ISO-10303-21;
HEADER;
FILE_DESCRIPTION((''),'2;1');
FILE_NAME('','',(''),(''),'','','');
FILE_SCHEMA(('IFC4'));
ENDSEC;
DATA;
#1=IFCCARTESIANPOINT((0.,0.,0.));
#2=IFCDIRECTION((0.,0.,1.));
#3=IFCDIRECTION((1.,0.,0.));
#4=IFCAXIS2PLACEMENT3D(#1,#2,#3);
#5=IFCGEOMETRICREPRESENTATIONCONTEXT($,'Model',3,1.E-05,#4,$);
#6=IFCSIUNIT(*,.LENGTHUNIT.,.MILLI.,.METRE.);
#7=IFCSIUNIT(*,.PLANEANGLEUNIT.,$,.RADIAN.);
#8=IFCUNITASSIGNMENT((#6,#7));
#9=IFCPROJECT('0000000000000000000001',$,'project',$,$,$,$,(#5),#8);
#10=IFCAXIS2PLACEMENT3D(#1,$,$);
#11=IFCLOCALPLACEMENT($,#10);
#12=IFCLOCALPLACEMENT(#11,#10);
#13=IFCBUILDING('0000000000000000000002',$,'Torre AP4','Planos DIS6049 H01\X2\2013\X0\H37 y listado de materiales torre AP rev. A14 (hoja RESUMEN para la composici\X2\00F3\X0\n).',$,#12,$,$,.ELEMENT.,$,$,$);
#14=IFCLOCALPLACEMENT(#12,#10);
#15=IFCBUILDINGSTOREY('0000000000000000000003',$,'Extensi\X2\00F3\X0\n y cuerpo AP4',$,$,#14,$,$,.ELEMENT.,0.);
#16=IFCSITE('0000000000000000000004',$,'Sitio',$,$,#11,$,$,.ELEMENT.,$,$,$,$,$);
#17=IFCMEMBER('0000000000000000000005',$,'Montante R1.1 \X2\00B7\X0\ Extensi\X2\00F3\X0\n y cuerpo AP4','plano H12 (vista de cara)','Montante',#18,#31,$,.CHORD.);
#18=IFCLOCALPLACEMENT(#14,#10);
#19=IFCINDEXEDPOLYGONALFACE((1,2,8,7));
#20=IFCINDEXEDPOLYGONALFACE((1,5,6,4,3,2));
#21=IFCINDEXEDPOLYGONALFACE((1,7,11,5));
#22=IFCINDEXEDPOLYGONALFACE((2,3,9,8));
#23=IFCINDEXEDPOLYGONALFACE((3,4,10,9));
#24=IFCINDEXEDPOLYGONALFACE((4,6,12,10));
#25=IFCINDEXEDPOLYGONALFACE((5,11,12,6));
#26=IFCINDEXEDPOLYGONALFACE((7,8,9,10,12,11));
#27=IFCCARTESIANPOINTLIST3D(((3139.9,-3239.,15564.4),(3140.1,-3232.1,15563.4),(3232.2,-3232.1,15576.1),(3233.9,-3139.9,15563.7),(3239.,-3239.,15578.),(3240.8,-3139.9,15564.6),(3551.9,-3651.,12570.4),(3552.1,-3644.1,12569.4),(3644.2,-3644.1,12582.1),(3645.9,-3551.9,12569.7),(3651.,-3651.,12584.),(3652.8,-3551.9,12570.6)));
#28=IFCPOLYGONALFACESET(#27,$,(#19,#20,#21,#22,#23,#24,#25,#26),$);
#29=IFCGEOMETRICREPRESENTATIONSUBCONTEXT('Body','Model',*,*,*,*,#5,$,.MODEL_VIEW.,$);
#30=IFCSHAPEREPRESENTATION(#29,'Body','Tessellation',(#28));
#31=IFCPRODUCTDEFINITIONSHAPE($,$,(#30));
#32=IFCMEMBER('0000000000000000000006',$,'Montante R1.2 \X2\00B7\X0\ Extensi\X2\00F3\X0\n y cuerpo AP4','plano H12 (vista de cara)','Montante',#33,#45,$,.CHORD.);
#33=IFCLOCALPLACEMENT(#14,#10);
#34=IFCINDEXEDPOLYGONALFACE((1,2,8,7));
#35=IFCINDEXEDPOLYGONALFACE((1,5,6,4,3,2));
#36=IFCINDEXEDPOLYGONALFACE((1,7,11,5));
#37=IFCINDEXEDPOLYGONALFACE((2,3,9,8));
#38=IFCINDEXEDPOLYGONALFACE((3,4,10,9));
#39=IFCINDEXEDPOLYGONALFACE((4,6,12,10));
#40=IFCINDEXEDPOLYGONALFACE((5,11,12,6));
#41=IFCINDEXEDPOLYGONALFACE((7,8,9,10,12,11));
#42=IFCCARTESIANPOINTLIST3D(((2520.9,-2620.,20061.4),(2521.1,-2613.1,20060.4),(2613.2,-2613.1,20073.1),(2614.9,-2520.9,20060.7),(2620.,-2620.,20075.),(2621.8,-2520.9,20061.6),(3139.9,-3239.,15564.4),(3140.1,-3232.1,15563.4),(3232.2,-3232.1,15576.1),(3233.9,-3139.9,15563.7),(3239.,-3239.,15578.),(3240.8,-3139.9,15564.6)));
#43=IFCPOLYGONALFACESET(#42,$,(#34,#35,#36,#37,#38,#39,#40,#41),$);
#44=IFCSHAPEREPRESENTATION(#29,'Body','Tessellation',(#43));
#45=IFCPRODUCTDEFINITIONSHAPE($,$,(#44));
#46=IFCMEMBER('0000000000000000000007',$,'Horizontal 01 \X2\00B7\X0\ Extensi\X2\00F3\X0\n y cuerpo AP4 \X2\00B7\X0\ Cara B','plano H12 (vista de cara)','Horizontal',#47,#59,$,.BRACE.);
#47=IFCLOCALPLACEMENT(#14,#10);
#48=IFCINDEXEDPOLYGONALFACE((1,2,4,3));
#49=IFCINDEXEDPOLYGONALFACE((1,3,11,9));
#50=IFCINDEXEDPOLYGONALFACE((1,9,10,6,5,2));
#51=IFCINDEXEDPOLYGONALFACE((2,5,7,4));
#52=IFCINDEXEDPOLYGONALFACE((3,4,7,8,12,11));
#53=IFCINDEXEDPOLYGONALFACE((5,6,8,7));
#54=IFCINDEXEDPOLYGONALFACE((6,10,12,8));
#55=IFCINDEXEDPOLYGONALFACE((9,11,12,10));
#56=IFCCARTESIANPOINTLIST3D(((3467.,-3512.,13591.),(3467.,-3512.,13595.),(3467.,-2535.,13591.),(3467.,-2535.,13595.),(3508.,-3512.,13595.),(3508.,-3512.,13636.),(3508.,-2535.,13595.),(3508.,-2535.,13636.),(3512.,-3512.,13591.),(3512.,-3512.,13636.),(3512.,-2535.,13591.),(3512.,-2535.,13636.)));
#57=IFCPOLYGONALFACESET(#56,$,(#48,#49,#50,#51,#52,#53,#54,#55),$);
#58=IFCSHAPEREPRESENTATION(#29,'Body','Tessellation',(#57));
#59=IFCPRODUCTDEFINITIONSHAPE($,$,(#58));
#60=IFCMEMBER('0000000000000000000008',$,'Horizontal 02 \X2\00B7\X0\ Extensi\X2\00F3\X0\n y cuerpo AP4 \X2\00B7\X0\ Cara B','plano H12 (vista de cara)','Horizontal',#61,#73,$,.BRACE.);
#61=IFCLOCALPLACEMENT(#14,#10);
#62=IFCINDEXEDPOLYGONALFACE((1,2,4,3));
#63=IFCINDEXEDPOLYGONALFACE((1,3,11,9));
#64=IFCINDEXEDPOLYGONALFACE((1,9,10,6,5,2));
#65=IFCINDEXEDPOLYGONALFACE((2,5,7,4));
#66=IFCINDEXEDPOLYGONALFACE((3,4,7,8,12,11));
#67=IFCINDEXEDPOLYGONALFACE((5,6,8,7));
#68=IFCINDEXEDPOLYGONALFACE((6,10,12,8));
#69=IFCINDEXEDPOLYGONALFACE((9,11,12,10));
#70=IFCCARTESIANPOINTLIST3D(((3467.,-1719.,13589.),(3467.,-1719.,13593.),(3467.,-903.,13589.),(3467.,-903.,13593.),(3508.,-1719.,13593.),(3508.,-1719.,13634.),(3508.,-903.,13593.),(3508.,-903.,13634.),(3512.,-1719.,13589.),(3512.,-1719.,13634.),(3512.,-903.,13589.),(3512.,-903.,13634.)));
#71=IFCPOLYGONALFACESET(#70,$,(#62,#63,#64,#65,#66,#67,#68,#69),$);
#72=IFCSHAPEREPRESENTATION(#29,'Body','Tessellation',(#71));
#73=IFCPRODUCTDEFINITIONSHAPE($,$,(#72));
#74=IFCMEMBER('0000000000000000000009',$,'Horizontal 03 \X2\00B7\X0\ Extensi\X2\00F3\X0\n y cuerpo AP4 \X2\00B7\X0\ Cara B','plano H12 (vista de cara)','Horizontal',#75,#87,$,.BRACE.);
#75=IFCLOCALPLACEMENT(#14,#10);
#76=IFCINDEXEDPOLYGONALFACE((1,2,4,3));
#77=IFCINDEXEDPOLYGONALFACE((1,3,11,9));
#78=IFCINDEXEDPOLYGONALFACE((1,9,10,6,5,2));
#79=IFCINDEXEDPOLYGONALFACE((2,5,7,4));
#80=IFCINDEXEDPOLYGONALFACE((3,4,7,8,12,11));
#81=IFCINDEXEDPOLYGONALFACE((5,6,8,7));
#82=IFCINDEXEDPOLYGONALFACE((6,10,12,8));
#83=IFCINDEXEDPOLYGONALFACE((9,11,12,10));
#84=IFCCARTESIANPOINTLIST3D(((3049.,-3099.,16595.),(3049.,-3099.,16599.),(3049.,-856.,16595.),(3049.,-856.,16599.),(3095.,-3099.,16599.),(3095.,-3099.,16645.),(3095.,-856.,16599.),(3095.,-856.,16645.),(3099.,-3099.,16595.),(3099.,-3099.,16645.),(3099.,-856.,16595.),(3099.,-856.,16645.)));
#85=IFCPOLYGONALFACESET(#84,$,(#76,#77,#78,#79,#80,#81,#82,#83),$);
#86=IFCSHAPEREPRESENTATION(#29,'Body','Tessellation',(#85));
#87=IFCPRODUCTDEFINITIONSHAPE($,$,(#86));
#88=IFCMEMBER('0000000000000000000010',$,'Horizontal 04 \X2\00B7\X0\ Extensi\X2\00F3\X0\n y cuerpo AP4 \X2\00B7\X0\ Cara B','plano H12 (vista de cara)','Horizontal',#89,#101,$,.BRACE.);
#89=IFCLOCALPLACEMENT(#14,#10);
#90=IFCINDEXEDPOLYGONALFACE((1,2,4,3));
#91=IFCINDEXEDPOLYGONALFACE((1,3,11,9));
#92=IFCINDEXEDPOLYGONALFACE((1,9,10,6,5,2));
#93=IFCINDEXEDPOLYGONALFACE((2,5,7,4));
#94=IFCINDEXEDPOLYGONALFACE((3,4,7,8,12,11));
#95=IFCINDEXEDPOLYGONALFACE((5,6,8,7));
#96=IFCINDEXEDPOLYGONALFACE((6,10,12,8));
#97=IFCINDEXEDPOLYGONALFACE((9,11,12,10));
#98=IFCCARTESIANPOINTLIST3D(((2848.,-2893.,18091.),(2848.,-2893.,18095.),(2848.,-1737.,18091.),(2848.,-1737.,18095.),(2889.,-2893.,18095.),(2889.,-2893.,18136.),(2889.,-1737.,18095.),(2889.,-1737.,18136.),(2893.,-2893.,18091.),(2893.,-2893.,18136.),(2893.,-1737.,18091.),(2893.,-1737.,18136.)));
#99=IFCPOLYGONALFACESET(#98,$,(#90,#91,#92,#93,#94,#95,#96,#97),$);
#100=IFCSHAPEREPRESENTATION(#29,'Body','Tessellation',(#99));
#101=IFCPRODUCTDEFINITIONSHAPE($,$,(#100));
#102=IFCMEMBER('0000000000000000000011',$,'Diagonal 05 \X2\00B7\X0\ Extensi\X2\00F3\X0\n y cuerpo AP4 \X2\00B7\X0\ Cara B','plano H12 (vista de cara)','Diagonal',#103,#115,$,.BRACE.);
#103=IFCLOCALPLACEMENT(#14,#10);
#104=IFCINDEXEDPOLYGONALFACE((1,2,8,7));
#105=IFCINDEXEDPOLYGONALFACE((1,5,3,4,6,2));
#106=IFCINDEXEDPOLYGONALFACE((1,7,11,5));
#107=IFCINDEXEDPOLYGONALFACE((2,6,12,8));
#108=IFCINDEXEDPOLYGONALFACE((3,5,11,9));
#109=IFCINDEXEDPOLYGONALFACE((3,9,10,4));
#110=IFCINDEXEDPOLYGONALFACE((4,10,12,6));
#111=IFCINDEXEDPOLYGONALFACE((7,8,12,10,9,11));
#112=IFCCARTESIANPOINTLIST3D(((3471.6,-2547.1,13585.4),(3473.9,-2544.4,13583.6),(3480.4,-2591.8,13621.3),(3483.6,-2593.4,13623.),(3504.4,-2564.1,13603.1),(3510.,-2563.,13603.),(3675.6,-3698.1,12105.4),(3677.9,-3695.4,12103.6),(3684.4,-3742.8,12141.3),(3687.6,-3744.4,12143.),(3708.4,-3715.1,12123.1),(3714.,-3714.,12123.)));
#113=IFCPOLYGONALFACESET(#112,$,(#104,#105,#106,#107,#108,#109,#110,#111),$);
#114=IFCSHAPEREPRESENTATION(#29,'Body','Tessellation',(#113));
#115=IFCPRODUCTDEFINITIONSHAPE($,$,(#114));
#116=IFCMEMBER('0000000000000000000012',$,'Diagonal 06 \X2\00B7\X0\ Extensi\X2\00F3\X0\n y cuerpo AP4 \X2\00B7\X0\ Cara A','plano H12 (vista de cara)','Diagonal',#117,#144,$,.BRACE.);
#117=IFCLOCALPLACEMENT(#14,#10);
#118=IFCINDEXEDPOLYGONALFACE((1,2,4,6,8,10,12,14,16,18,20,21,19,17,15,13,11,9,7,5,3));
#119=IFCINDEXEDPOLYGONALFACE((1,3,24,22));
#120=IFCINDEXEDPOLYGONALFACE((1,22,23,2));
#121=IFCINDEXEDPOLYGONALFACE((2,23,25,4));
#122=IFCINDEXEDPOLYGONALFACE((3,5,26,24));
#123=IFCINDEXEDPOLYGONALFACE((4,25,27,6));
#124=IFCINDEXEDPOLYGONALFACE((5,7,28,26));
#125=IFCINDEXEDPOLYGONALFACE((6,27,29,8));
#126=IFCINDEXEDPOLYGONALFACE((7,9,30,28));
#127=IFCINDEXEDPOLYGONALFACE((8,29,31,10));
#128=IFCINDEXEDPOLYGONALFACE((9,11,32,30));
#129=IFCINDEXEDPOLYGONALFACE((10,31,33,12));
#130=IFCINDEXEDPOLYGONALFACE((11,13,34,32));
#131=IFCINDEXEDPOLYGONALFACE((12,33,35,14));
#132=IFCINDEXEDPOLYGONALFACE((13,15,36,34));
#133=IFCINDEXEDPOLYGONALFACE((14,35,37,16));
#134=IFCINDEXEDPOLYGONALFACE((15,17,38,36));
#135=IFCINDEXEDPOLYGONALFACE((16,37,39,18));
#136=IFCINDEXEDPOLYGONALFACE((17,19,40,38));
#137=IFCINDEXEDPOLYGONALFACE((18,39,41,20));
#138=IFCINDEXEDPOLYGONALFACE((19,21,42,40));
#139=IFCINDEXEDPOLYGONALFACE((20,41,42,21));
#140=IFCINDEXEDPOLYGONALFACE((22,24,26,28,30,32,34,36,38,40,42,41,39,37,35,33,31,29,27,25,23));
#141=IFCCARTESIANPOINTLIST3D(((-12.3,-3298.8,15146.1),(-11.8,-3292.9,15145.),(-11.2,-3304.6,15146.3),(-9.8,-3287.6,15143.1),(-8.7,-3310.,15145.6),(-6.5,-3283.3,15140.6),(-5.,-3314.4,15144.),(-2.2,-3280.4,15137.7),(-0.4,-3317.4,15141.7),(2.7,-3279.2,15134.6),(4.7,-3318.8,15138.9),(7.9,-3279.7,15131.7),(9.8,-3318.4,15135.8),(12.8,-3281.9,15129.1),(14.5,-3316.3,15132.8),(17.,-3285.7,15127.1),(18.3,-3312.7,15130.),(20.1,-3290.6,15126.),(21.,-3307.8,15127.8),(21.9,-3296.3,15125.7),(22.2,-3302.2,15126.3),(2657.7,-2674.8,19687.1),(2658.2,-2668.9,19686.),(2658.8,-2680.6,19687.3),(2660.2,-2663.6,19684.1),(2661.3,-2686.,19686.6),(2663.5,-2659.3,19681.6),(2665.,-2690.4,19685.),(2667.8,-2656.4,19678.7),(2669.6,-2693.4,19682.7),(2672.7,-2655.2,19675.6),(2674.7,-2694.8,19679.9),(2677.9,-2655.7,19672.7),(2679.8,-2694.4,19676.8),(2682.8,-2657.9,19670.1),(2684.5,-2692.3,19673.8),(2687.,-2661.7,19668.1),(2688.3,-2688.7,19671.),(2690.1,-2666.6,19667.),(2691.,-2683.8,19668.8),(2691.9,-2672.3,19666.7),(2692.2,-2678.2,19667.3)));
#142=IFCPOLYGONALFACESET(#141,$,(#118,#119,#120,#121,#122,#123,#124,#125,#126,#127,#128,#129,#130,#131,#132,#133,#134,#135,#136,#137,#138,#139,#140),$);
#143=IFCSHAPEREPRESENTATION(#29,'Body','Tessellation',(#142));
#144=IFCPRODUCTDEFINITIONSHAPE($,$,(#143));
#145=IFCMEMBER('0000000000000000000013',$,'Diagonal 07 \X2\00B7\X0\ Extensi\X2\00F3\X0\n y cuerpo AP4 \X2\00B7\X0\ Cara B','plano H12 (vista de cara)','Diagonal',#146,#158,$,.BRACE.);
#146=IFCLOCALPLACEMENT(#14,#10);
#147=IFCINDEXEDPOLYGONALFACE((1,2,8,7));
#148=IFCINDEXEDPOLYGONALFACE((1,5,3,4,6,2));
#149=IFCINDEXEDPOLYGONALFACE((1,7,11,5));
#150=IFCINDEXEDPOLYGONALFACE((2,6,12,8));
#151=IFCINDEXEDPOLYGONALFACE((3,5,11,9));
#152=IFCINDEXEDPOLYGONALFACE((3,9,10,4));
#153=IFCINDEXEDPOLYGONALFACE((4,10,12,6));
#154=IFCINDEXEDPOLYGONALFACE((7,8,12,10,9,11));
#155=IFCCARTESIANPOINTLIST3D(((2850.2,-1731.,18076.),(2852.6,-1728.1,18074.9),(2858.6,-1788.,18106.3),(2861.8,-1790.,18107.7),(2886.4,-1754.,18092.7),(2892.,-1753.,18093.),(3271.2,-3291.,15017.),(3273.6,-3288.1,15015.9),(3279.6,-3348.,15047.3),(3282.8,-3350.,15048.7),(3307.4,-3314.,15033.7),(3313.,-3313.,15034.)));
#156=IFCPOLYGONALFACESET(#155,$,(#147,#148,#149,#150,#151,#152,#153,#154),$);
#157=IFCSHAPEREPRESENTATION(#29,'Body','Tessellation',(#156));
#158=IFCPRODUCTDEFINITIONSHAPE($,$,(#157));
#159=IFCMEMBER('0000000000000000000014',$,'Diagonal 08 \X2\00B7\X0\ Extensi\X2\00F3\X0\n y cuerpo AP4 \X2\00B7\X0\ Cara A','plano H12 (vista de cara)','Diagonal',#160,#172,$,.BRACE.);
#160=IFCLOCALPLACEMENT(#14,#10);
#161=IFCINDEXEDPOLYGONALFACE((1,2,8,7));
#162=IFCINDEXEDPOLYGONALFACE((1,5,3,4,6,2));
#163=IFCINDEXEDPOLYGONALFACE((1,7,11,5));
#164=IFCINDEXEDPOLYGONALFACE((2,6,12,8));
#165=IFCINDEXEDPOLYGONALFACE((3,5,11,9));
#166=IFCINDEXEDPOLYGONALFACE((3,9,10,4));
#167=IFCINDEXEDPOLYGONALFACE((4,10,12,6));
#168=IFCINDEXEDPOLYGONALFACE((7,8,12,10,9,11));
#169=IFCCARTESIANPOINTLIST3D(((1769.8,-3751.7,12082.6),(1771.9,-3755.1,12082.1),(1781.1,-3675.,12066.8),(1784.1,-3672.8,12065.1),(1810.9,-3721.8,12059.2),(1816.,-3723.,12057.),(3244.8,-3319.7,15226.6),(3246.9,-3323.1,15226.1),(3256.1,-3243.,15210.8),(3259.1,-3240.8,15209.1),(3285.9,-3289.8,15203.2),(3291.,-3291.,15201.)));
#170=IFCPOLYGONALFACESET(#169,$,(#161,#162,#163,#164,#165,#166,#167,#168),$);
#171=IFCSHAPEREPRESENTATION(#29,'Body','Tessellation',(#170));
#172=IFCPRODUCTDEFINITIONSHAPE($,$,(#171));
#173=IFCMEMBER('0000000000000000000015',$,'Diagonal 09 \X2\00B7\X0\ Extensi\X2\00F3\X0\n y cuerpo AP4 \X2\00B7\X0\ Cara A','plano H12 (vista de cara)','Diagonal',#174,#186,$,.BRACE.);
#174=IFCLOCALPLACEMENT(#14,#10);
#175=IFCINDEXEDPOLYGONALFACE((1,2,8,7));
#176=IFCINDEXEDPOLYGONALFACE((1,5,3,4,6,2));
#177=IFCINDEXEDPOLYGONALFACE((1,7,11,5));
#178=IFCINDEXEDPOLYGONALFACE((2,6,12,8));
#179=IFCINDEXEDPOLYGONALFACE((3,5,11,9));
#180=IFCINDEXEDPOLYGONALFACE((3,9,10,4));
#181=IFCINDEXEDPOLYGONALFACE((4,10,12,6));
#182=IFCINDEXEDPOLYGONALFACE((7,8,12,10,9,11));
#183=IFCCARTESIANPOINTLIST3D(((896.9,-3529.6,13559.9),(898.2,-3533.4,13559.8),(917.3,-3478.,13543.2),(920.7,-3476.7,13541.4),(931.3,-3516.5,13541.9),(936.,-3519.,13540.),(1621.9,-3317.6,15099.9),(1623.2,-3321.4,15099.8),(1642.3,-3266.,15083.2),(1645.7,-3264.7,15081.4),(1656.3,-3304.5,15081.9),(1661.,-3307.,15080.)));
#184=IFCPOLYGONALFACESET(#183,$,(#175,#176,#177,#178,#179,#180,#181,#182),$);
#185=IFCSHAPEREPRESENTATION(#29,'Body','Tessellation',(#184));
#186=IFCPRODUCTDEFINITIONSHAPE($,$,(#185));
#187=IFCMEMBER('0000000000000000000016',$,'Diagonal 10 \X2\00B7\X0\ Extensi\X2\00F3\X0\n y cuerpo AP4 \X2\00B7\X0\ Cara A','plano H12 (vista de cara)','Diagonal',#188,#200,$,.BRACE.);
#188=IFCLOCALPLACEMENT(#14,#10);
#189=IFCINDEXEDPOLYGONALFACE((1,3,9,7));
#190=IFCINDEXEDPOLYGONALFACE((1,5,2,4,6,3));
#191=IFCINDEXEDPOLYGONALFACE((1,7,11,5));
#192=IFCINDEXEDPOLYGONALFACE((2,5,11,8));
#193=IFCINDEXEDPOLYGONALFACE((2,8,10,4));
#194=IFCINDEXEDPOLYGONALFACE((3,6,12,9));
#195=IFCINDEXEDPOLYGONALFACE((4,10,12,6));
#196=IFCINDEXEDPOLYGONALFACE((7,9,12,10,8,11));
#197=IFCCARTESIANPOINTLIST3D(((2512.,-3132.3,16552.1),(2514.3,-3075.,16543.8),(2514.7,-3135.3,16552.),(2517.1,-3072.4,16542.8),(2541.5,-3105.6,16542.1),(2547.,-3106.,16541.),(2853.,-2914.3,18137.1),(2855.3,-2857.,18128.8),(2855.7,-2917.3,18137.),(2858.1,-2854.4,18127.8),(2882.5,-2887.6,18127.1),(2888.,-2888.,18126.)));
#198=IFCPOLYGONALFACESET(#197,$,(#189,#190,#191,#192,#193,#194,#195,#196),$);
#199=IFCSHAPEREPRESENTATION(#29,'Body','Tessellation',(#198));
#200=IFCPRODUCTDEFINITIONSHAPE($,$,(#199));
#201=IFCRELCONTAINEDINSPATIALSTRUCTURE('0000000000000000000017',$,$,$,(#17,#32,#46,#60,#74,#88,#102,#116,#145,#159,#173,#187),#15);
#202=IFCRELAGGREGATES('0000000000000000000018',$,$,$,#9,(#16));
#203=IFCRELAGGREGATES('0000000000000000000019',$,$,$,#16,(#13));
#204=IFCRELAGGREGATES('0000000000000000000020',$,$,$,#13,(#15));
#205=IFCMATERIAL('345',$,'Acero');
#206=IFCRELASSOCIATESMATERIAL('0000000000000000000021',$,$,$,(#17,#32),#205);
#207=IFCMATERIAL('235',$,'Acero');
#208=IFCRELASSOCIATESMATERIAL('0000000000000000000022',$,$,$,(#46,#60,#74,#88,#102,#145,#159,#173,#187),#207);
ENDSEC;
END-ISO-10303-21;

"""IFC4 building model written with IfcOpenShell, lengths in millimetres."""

from ifc_helpers import new_model, si_unit, frame, frame_2d, origin, origin_with_axes, place, context, subcontext, project, spatial, circle, l_section, extrude, material, element, save


model = new_model("IFC4")

# Units and contexts
model_context = context("Model", 3, precision=1e-05, world=origin_with_axes())
body_context = subcontext(model_context, "Body", "Model", "MODEL_VIEW")
ifc_project = project(units=[si_unit("LENGTHUNIT", "METRE", prefix="MILLI"), si_unit("PLANEANGLEUNIT", "RADIAN")], contexts=[model_context])

# Site, building, storey
site_placement = place(None, origin())
site = spatial("IfcSite", under=ifc_project, at=site_placement, Name="Sitio", CompositionType="ELEMENT")
building_placement = place(site_placement, origin())
building = spatial("IfcBuilding", under=site, at=building_placement, Name="Torre AP4", Description="Planos DIS6049 H01–H37 y listado de materiales torre AP rev. A14 (hoja RESUMEN para la composición).", CompositionType="ELEMENT")
storey_placement = place(building_placement, origin())
storey = spatial("IfcBuildingStorey", under=building, at=storey_placement, Name="Extensión y cuerpo AP4", CompositionType="ELEMENT", Elevation=0.0)

# Members
ifc_material_1 = material(Name="345", Category="Acero")
member_1_placement = place(storey_placement, frame((3651.0, -3651.0, 12584.0), z_axis=(-0.135075, 0.135075, 0.981585), x_axis=(0.018414, 0.990835, -0.133814)))
element("IfcMember", 1, at=member_1_placement, inside=storey, material=ifc_material_1, Name="Montante R1.1 · Extensión y cuerpo AP4", Description="plano H12 (vista de cara)", ObjectType="Montante", PredefinedType="CHORD", context=body_context, shape_type="SweptSolid", body=[
    extrude(l_section(Depth=100.0, Width=100.0, Thickness=7.0, at=frame_2d((50.0, 50.0))), None, (0.0, 0.0, 1.0), 3050.2),
])
member_2_placement = place(storey_placement, frame((3239.0, -3239.0, 15578.0), z_axis=(-0.135111, 0.135111, 0.981575), x_axis=(0.018424, 0.99083, -0.133849)))
element("IfcMember", 2, at=member_2_placement, inside=storey, material=ifc_material_1, Name="Montante R1.2 · Extensión y cuerpo AP4", Description="plano H12 (vista de cara)", ObjectType="Montante", PredefinedType="CHORD", context=body_context, shape_type="SweptSolid", body=[
    extrude(l_section(Depth=100.0, Width=100.0, Thickness=7.0, at=frame_2d((50.0, 50.0))), None, (0.0, 0.0, 1.0), 4581.4),
])
ifc_material_2 = material(Name="235", Category="Acero")
member_3_placement = place(storey_placement, frame((3512.0, -3512.0, 13591.0), z_axis=(0.0, 1.0, 0.0), x_axis=(-1.0, 0.0, 0.0)))
element("IfcMember", 3, at=member_3_placement, inside=storey, material=ifc_material_2, Name="Horizontal 01 · Extensión y cuerpo AP4 · Cara B", Description="plano H12 (vista de cara)", ObjectType="Horizontal", PredefinedType="BRACE", context=body_context, shape_type="SweptSolid", body=[
    extrude(l_section(Depth=45.0, Width=45.0, Thickness=4.0, at=frame_2d((22.5, 22.5))), None, (0.0, 0.0, 1.0), 977.0),
])
member_4_placement = place(storey_placement, frame((3512.0, -1719.0, 13589.0), z_axis=(0.0, 1.0, 0.0), x_axis=(-1.0, 0.0, 0.0)))
element("IfcMember", 4, at=member_4_placement, inside=storey, material=ifc_material_2, Name="Horizontal 02 · Extensión y cuerpo AP4 · Cara B", Description="plano H12 (vista de cara)", ObjectType="Horizontal", PredefinedType="BRACE", context=body_context, shape_type="SweptSolid", body=[
    extrude(l_section(Depth=45.0, Width=45.0, Thickness=4.0, at=frame_2d((22.5, 22.5))), None, (0.0, 0.0, 1.0), 816.0),
])
member_5_placement = place(storey_placement, frame((3099.0, -3099.0, 16595.0), z_axis=(0.0, 1.0, 0.0), x_axis=(-1.0, 0.0, 0.0)))
element("IfcMember", 5, at=member_5_placement, inside=storey, material=ifc_material_2, Name="Horizontal 03 · Extensión y cuerpo AP4 · Cara B", Description="plano H12 (vista de cara)", ObjectType="Horizontal", PredefinedType="BRACE", context=body_context, shape_type="SweptSolid", body=[
    extrude(l_section(Depth=50.0, Width=50.0, Thickness=4.0, at=frame_2d((25.0, 25.0))), None, (0.0, 0.0, 1.0), 2243.0),
])
member_6_placement = place(storey_placement, frame((2893.0, -2893.0, 18091.0), z_axis=(0.0, 1.0, 0.0), x_axis=(-1.0, 0.0, 0.0)))
element("IfcMember", 6, at=member_6_placement, inside=storey, material=ifc_material_2, Name="Horizontal 04 · Extensión y cuerpo AP4 · Cara B", Description="plano H12 (vista de cara)", ObjectType="Horizontal", PredefinedType="BRACE", context=body_context, shape_type="SweptSolid", body=[
    extrude(l_section(Depth=45.0, Width=45.0, Thickness=4.0, at=frame_2d((22.5, 22.5))), None, (0.0, 0.0, 1.0), 1156.0),
])
member_7_placement = place(storey_placement, frame((3714.0, -3714.0, 12123.0), z_axis=(-0.108168, 0.610302, 0.784749), x_axis=(-0.802007, 0.412878, -0.431644)))
element("IfcMember", 7, at=member_7_placement, inside=storey, material=ifc_material_2, Name="Diagonal 05 · Extensión y cuerpo AP4 · Cara B", Description="plano H12 (vista de cara)", ObjectType="Diagonal", PredefinedType="BRACE", context=body_context, shape_type="SweptSolid", body=[
    extrude(l_section(Depth=45.0, Width=45.0, Thickness=4.0, at=frame_2d((22.5, 22.5))), None, (0.0, 0.0, 1.0), 1886.0),
])
member_8_placement = place(storey_placement, frame((5.0, -3299.0, 15136.0), z_axis=(0.503335, 0.117633, 0.856047), x_axis=(-0.361399, 0.928538, 0.0849)))
element("IfcMember", 8, at=member_8_placement, inside=storey, Name="Diagonal 06 · Extensión y cuerpo AP4 · Cara A", Description="plano H12 (vista de cara)", ObjectType="Diagonal", PredefinedType="BRACE", context=body_context, shape_type="SweptSolid", body=[
    extrude(circle(Radius=20.0), None, (0.0, 0.0, 1.0), 5304.6),
])
member_9_placement = place(storey_placement, frame((3313.0, -3313.0, 15034.0), z_axis=(-0.121693, 0.450929, 0.884225), x_axis=(-0.787324, 0.498615, -0.362636)))
element("IfcMember", 9, at=member_9_placement, inside=storey, material=ifc_material_2, Name="Diagonal 07 · Extensión y cuerpo AP4 · Cara B", Description="plano H12 (vista de cara)", ObjectType="Diagonal", PredefinedType="BRACE", context=body_context, shape_type="SweptSolid", body=[
    extrude(l_section(Depth=50.0, Width=50.0, Thickness=4.0, at=frame_2d((25.0, 25.0))), None, (0.0, 0.0, 1.0), 3459.5),
])
member_10_placement = place(storey_placement, frame((1816.0, -3723.0, 12057.0), z_axis=(0.42148, 0.123444, 0.898396), x_axis=(-0.531995, 0.835962, 0.134719)))
element("IfcMember", 10, at=member_10_placement, inside=storey, material=ifc_material_2, Name="Diagonal 08 · Extensión y cuerpo AP4 · Cara A", Description="plano H12 (vista de cara)", ObjectType="Diagonal", PredefinedType="BRACE", context=body_context, shape_type="SweptSolid", body=[
    extrude(l_section(Depth=60.0, Width=60.0, Thickness=4.0, at=frame_2d((30.0, 30.0))), None, (0.0, 0.0, 1.0), 3499.6),
])
member_11_placement = place(storey_placement, frame((936.0, -3519.0, 13540.0), z_axis=(0.422673, 0.123595, 0.897815), x_axis=(-0.341096, 0.939509, 0.031246)))
element("IfcMember", 11, at=member_11_placement, inside=storey, material=ifc_material_2, Name="Diagonal 09 · Extensión y cuerpo AP4 · Cara A", Description="plano H12 (vista de cara)", ObjectType="Diagonal", PredefinedType="BRACE", context=body_context, shape_type="SweptSolid", body=[
    extrude(l_section(Depth=45.0, Width=45.0, Thickness=4.0, at=frame_2d((22.5, 22.5))), None, (0.0, 0.0, 1.0), 1715.3),
])
member_12_placement = place(storey_placement, frame((2547.0, -3106.0, 16541.0), z_axis=(0.208453, 0.133263, 0.968911), x_axis=(-0.663676, 0.746947, 0.04005)))
element("IfcMember", 12, at=member_12_placement, inside=storey, material=ifc_material_2, Name="Diagonal 10 · Extensión y cuerpo AP4 · Cara A", Description="plano H12 (vista de cara)", ObjectType="Diagonal", PredefinedType="BRACE", context=body_context, shape_type="SweptSolid", body=[
    extrude(l_section(Depth=45.0, Width=45.0, Thickness=4.0, at=frame_2d((22.5, 22.5))), None, (0.0, 0.0, 1.0), 1635.9),
])

save(model, "model.ifc")
